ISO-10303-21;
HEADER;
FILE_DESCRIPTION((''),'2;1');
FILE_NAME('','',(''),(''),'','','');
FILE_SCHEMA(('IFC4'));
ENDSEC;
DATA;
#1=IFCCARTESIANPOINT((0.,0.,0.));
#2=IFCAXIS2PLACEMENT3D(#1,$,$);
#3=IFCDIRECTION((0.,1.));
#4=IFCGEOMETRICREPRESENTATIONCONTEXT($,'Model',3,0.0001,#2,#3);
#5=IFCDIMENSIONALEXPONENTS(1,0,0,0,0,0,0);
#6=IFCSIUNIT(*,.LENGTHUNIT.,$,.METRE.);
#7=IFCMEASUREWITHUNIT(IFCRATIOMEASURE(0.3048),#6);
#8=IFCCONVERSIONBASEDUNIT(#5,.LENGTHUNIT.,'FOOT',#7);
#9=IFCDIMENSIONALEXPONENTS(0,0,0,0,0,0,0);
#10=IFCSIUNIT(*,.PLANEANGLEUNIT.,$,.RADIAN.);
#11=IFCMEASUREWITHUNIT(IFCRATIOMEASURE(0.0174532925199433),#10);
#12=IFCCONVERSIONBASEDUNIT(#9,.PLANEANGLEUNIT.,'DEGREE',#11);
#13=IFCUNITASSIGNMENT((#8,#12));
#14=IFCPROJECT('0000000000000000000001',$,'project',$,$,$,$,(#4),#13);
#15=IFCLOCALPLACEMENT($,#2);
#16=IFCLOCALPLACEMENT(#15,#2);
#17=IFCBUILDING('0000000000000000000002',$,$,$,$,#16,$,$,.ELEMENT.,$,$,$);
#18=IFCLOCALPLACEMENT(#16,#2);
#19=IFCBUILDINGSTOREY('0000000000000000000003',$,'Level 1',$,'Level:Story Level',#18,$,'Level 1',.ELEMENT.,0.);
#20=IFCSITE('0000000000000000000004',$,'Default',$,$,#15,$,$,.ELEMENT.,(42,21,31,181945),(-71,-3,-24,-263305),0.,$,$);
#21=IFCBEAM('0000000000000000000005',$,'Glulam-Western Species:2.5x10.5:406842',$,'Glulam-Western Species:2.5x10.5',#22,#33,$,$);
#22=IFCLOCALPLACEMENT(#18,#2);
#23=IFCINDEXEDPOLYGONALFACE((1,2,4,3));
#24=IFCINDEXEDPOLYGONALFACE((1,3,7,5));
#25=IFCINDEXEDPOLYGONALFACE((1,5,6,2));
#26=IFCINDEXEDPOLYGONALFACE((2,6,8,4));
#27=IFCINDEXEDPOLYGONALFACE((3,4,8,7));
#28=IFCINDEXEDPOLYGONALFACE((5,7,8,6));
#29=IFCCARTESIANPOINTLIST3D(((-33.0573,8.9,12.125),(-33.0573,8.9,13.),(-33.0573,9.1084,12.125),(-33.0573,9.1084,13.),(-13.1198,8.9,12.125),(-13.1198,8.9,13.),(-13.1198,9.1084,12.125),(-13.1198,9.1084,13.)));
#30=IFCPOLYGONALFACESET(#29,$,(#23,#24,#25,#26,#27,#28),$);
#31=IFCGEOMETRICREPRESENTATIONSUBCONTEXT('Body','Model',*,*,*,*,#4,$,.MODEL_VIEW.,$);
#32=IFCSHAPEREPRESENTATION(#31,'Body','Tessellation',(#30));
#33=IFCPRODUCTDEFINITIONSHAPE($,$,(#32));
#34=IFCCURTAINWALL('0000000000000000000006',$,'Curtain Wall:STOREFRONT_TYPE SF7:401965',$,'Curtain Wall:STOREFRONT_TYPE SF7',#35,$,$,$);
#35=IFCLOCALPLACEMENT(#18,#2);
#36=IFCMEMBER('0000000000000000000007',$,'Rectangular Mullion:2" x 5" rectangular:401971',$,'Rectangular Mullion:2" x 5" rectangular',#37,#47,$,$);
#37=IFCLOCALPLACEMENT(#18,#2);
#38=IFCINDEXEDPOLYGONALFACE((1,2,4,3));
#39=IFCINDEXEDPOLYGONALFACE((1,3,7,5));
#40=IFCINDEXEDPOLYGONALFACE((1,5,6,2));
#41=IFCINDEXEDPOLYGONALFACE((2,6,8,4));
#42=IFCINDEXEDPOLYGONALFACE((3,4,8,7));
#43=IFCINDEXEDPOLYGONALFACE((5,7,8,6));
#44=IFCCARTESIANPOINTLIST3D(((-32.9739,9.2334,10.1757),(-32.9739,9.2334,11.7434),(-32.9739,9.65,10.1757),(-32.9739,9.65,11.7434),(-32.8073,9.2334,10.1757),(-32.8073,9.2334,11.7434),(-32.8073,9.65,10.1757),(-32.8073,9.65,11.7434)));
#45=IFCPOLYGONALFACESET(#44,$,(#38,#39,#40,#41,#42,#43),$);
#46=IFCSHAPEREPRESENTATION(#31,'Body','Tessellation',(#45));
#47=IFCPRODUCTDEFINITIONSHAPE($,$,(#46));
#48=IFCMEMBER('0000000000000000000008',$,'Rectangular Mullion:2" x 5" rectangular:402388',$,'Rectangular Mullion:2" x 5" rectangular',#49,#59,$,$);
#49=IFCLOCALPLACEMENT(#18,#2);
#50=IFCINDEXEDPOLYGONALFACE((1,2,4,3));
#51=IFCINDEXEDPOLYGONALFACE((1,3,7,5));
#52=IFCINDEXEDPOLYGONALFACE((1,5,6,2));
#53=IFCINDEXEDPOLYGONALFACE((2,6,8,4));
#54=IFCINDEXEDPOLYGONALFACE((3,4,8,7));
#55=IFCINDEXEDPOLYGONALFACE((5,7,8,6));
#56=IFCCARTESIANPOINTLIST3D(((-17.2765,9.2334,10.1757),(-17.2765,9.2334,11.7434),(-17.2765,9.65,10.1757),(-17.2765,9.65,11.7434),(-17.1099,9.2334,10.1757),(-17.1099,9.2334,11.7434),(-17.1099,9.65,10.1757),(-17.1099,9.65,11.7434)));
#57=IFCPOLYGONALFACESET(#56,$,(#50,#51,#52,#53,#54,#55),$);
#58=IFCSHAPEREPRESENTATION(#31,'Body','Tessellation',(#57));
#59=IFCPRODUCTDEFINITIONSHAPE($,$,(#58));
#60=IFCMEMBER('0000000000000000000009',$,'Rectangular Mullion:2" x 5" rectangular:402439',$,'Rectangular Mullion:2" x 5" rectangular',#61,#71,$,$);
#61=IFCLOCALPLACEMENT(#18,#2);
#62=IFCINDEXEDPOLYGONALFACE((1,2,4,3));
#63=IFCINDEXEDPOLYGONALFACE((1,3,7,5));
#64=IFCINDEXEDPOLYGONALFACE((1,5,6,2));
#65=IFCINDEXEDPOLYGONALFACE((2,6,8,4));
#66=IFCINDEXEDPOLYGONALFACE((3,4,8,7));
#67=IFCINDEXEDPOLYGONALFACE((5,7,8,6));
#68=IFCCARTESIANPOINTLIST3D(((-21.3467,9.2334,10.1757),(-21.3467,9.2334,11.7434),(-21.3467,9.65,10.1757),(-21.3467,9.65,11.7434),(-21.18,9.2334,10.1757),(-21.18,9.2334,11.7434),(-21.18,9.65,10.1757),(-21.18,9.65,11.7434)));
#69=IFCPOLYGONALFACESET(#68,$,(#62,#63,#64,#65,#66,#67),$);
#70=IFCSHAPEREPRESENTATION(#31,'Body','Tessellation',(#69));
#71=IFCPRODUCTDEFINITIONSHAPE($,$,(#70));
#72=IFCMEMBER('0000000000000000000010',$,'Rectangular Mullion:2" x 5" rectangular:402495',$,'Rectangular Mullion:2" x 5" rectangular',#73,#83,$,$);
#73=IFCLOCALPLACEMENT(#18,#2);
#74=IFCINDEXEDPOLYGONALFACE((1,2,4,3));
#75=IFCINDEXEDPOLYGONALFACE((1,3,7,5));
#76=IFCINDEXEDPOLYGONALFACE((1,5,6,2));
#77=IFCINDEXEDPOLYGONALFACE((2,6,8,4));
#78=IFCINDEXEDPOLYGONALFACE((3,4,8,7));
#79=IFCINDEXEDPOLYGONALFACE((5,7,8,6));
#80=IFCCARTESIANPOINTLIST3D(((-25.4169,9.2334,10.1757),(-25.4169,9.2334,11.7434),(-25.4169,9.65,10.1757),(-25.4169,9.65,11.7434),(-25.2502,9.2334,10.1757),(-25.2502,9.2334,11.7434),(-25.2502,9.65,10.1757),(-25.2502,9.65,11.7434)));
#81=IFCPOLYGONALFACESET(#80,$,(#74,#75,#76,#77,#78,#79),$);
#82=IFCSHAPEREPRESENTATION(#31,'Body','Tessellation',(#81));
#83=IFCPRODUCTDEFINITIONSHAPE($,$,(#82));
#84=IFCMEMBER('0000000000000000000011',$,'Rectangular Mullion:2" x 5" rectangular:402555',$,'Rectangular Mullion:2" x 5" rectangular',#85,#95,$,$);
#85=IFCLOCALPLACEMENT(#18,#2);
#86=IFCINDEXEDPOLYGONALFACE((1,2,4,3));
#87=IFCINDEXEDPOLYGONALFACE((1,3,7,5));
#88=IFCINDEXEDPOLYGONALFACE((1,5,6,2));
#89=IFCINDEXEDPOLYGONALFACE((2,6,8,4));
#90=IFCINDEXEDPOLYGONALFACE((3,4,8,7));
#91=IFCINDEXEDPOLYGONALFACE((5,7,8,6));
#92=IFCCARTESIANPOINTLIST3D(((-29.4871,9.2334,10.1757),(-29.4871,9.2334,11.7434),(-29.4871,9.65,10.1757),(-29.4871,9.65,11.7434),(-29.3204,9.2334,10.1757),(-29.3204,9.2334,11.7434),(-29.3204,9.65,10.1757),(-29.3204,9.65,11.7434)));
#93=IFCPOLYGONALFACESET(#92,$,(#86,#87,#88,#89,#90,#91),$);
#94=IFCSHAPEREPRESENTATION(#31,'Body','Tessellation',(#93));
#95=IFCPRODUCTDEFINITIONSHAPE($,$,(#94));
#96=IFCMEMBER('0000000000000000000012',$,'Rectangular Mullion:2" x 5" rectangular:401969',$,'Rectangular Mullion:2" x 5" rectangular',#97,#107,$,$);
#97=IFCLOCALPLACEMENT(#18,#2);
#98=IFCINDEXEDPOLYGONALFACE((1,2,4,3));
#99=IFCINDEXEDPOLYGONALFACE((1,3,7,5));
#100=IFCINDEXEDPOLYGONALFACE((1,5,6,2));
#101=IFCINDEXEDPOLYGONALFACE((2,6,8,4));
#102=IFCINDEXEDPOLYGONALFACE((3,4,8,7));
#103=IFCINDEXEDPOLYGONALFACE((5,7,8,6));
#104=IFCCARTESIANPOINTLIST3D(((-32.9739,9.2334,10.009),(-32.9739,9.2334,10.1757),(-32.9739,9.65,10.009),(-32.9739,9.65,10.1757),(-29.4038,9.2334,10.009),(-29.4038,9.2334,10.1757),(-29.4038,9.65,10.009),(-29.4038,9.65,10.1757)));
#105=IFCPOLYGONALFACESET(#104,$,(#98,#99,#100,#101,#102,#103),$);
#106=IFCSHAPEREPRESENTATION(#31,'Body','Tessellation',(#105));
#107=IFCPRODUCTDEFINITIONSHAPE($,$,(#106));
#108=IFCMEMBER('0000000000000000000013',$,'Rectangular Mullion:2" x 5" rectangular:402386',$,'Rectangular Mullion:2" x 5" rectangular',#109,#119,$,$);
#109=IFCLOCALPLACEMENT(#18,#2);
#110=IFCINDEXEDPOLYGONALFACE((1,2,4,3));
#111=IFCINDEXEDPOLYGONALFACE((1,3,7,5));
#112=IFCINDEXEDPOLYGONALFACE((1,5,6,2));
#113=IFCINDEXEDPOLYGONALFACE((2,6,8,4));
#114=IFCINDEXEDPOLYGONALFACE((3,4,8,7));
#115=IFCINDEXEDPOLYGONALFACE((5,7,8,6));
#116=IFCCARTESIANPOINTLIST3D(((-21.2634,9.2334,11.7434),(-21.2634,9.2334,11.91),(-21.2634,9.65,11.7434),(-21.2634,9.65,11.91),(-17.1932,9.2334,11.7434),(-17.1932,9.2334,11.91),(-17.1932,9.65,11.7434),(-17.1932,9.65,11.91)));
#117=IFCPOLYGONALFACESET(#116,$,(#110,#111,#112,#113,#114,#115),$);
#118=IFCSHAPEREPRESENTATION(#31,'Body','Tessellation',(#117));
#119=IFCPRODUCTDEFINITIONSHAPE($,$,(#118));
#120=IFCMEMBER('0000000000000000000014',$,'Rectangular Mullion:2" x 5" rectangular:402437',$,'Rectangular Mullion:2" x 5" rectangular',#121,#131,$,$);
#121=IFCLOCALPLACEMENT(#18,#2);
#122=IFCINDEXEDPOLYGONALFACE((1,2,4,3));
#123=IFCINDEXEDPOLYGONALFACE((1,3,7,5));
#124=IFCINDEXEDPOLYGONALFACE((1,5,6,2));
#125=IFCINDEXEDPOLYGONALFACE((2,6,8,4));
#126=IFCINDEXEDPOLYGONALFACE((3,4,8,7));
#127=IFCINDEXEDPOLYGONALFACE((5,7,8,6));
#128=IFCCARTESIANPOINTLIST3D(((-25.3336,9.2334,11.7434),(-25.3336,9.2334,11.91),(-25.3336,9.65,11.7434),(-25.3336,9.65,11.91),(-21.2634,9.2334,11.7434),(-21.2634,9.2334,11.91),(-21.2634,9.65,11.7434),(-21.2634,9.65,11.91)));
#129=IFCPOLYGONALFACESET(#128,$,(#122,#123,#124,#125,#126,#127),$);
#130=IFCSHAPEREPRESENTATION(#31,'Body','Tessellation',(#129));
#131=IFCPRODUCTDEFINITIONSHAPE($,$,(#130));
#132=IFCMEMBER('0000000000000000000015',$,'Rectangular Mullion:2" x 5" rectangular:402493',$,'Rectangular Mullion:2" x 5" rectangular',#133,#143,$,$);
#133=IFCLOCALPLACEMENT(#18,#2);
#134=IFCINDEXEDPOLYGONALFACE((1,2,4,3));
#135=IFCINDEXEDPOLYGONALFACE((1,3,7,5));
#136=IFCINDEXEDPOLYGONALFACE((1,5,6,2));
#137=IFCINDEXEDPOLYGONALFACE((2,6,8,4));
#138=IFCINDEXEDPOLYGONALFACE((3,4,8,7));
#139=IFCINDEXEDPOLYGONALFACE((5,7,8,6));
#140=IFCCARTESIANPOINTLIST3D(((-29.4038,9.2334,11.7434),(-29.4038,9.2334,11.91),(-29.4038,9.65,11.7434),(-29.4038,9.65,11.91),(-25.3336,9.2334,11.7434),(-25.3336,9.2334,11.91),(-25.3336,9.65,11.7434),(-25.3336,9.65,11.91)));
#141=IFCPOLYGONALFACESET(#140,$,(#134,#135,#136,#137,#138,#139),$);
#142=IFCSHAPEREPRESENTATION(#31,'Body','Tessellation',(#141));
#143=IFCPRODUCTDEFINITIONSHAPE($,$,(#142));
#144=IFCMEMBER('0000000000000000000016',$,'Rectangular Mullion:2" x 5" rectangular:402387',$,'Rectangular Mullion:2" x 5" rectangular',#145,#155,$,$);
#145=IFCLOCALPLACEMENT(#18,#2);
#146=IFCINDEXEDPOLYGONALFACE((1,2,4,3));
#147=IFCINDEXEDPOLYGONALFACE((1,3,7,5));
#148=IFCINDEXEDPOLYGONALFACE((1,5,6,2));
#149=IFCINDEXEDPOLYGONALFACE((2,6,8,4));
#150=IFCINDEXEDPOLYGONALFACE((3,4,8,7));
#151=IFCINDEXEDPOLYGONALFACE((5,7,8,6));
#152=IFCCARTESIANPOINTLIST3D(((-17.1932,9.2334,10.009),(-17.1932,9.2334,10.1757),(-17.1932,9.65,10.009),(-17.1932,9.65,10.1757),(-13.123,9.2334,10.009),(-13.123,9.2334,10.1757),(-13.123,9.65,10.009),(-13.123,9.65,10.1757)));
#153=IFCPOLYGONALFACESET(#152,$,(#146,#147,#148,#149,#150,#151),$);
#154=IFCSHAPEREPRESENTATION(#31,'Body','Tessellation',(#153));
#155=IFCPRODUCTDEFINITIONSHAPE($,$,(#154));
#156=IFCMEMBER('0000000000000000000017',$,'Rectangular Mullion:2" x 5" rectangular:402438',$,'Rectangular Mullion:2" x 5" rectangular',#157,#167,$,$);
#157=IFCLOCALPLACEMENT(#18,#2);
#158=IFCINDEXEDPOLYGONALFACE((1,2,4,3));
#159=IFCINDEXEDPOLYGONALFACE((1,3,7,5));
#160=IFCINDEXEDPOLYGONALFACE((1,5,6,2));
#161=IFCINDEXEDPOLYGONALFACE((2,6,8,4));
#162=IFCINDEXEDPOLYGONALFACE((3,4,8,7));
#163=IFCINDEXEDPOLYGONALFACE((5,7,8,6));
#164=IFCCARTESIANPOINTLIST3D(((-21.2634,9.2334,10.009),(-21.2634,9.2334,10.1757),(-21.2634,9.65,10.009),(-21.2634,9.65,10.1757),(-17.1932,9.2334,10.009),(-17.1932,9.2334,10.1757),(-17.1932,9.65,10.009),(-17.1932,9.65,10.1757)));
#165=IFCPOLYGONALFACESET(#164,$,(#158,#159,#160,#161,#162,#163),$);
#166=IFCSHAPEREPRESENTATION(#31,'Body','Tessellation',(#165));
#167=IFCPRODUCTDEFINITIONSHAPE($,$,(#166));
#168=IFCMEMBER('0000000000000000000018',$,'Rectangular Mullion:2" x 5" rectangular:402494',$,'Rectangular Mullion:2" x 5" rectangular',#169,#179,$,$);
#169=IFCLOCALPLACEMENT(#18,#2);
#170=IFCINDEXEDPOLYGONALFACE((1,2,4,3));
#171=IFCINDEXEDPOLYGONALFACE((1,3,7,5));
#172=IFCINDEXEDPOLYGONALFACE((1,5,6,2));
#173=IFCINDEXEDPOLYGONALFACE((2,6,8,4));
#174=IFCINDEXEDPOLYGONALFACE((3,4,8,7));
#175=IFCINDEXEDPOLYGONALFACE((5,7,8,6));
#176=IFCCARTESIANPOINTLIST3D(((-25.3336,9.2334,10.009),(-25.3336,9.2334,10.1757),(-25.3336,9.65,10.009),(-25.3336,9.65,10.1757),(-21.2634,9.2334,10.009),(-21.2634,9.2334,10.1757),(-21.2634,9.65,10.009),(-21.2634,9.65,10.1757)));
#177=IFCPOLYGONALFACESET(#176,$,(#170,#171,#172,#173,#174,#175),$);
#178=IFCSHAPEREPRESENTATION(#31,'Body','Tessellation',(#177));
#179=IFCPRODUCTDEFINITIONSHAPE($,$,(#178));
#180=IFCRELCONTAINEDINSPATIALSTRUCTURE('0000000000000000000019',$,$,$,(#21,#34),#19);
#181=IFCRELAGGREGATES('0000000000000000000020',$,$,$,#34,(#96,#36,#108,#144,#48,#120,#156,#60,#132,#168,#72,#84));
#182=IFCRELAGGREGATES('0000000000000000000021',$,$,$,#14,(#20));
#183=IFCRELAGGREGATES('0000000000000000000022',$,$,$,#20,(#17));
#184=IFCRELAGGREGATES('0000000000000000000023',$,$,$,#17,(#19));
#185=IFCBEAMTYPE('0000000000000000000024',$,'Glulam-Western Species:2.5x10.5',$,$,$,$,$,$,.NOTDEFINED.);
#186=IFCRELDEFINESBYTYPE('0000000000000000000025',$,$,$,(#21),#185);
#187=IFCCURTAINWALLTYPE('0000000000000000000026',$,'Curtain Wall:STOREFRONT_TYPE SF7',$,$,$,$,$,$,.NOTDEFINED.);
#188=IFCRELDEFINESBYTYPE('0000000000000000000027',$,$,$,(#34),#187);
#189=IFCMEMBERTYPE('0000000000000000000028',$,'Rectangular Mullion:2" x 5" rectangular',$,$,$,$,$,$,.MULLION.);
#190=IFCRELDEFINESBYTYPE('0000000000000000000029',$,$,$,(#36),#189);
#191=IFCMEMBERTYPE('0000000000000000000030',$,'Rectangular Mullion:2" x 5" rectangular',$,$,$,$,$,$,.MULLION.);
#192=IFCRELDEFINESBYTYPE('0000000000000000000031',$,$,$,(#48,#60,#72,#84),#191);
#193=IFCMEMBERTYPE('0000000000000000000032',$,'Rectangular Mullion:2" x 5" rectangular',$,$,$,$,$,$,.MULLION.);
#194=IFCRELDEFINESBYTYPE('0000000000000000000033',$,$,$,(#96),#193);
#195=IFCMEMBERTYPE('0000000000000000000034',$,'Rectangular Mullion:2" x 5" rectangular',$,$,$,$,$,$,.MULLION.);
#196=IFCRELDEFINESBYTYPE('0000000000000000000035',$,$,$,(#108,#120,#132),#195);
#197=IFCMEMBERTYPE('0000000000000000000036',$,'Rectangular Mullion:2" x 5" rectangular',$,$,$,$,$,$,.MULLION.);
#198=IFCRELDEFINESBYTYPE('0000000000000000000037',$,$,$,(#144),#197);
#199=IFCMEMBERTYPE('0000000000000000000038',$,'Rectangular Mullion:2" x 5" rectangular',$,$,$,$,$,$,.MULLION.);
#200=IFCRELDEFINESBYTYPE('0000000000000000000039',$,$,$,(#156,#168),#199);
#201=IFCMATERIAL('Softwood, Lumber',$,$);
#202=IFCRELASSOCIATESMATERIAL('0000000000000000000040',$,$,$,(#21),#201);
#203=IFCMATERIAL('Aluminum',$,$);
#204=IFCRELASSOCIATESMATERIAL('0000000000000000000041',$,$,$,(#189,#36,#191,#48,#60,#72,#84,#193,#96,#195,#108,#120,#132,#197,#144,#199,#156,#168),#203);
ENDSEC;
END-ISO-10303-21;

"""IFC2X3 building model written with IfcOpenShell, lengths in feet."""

from ifc_helpers import new_model, entity, si_unit, converted_unit, direction, frame, frame_2d, origin, origin_2d_with_axis, place, context, subcontext, project, spatial, rectangle, extrude, source, transform, mapped, material, type_object, type_shapes, element, aggregate, save


model = new_model("IFC2X3")

# Units and contexts
model_context = context("Model", 3, precision=0.0001, world=origin(), true_north=direction((0.0, 1.0)))
body_context = subcontext(model_context, "Body", "Model", "MODEL_VIEW")
ifc_project = project(units=[converted_unit("LENGTHUNIT", "FOOT", entity("IfcRatioMeasure", 0.3048), si_unit("LENGTHUNIT", "METRE"), dimensions=[1, 0, 0, 0, 0, 0, 0]), converted_unit("PLANEANGLEUNIT", "DEGREE", entity("IfcRatioMeasure", 0.0174532925199433), si_unit("PLANEANGLEUNIT", "RADIAN"), dimensions=[0, 0, 0, 0, 0, 0, 0])], contexts=[model_context])

# Site, building, storey
site_placement = place(None, origin())
site = spatial("IfcSite", under=ifc_project, at=site_placement, Name="Default", CompositionType="ELEMENT", RefLatitude=(42, 21, 31, 181945), RefLongitude=(-71, -3, -24, -263305), RefElevation=0.0)
building_placement = place(site_placement, origin())
building = spatial("IfcBuilding", under=site, at=building_placement, CompositionType="ELEMENT")
storey_placement = place(building_placement, origin())
storey = spatial("IfcBuildingStorey", under=building, at=storey_placement, Name="Level 1", ObjectType="Level:Story Level", LongName="Level 1", CompositionType="ELEMENT", Elevation=0.0)

# Beam
ifc_material_1 = material(Name="Softwood, Lumber")
beam_type = type_object("IfcBeamType", Name="Glulam-Western Species:2.5x10.5", PredefinedType="NOTDEFINED")
beam_placement = place(storey_placement, frame((-40.0989, 9.0042, 13.0)))
element("IfcBeam", 1, at=beam_placement, inside=storey, type_object=beam_type, material=ifc_material_1, Name="Glulam-Western Species:2.5x10.5:406842", ObjectType="Glulam-Western Species:2.5x10.5", context=body_context, shape_type="SweptSolid", body=[
    extrude(rectangle(XDim=0.875, YDim=0.2083, at=frame_2d((0.0, 0.0), x_axis=(1.0, 0.0))), frame((7.0417, 0.0, -0.4375), z_axis=(1.0, 0.0, 0.0), x_axis=(0.0, 0.0, -1.0)), (0.0, 0.0, 1.0), 19.9375),
])

# Curtain wall, members
curtain_wall_type = type_object("IfcCurtainWallType", Name="Curtain Wall:STOREFRONT_TYPE SF7", PredefinedType="NOTDEFINED")
curtain_wall_placement = place(storey_placement, origin())
curtain_wall = element("IfcCurtainWall", 2, at=curtain_wall_placement, inside=storey, type_object=curtain_wall_type, Name="Curtain Wall:STOREFRONT_TYPE SF7:401965", ObjectType="Curtain Wall:STOREFRONT_TYPE SF7")
ifc_material_2 = material(Name="Aluminum")
member_type_1 = type_object("IfcMemberType", Name="Rectangular Mullion:2\" x 5\" rectangular", PredefinedType="MULLION", material=ifc_material_2)
shared_shape_1 = source(origin(), body_context, "Body", "SweptSolid", [
    extrude(rectangle(XDim=0.4167, YDim=0.1667, at=origin_2d_with_axis()), frame((-0.0833, 0.0, -1.5677), z_axis=(0.0, 0.0, 1.0), x_axis=(0.0, -1.0, 0.0)), (0.0, 0.0, 1.0), 1.5677),
])
type_shapes(member_type_1, [shared_shape_1])
member_1_placement = place(curtain_wall_placement, frame((-32.9739, 9.4417, 11.7434), z_axis=(0.0, 0.0, 1.0), x_axis=(-1.0, 0.0, 0.0)))
member_1 = element("IfcMember", 3, at=member_1_placement, type_object=member_type_1, material=ifc_material_2, Name="Rectangular Mullion:2\" x 5\" rectangular:401971", ObjectType="Rectangular Mullion:2\" x 5\" rectangular", context=body_context, shape_type="MappedRepresentation", body=[
    mapped(shared_shape_1, transform((0.0, 0.0, 0.0), scale=1.0)),
])
member_type_2 = type_object("IfcMemberType", Name="Rectangular Mullion:2\" x 5\" rectangular", PredefinedType="MULLION", material=ifc_material_2)
shared_shape_2 = source(origin(), body_context, "Body", "SweptSolid", [
    extrude(rectangle(XDim=0.4167, YDim=0.1667, at=origin_2d_with_axis()), frame((0.0, 0.0, -1.5677), z_axis=(0.0, 0.0, 1.0), x_axis=(0.0, -1.0, 0.0)), (0.0, 0.0, 1.0), 1.5677),
])
type_shapes(member_type_2, [shared_shape_2])
member_2_placement = place(curtain_wall_placement, frame((-17.1932, 9.4417, 10.1757), z_axis=(0.0, 0.0, -1.0), x_axis=(1.0, 0.0, 0.0)))
member_2 = element("IfcMember", 4, at=member_2_placement, type_object=member_type_2, material=ifc_material_2, Name="Rectangular Mullion:2\" x 5\" rectangular:402388", ObjectType="Rectangular Mullion:2\" x 5\" rectangular", context=body_context, shape_type="MappedRepresentation", body=[
    mapped(shared_shape_2, transform((0.0, 0.0, 0.0), scale=1.0)),
])
member_3_placement = place(curtain_wall_placement, frame((-21.2634, 9.4417, 10.1757), z_axis=(0.0, 0.0, -1.0), x_axis=(1.0, 0.0, 0.0)))
member_3 = element("IfcMember", 5, at=member_3_placement, type_object=member_type_2, material=ifc_material_2, Name="Rectangular Mullion:2\" x 5\" rectangular:402439", ObjectType="Rectangular Mullion:2\" x 5\" rectangular", context=body_context, shape_type="MappedRepresentation", body=[
    mapped(shared_shape_2, transform((0.0, 0.0, 0.0), scale=1.0)),
])
member_4_placement = place(curtain_wall_placement, frame((-25.3336, 9.4417, 10.1757), z_axis=(0.0, 0.0, -1.0), x_axis=(1.0, 0.0, 0.0)))
member_4 = element("IfcMember", 6, at=member_4_placement, type_object=member_type_2, material=ifc_material_2, Name="Rectangular Mullion:2\" x 5\" rectangular:402495", ObjectType="Rectangular Mullion:2\" x 5\" rectangular", context=body_context, shape_type="MappedRepresentation", body=[
    mapped(shared_shape_2, transform((0.0, 0.0, 0.0), scale=1.0)),
])
member_5_placement = place(curtain_wall_placement, frame((-29.4038, 9.4417, 10.1757), z_axis=(0.0, 0.0, -1.0), x_axis=(1.0, 0.0, 0.0)))
member_5 = element("IfcMember", 7, at=member_5_placement, type_object=member_type_2, material=ifc_material_2, Name="Rectangular Mullion:2\" x 5\" rectangular:402555", ObjectType="Rectangular Mullion:2\" x 5\" rectangular", context=body_context, shape_type="MappedRepresentation", body=[
    mapped(shared_shape_2, transform((0.0, 0.0, 0.0), scale=1.0)),
])
member_type_3 = type_object("IfcMemberType", Name="Rectangular Mullion:2\" x 5\" rectangular", PredefinedType="MULLION", material=ifc_material_2)
shared_shape_3 = source(origin(), body_context, "Body", "SweptSolid", [
    extrude(rectangle(XDim=0.4167, YDim=0.1667, at=origin_2d_with_axis()), frame((-0.0833, 0.0, -3.5702), z_axis=(0.0, 0.0, 1.0), x_axis=(0.0, -1.0, 0.0)), (0.0, 0.0, 1.0), 3.5702),
])
type_shapes(member_type_3, [shared_shape_3])
member_6_placement = place(curtain_wall_placement, frame((-32.9739, 9.4417, 10.009), z_axis=(-1.0, 0.0, 0.0), x_axis=(0.0, 0.0, -1.0)))
member_6 = element("IfcMember", 8, at=member_6_placement, type_object=member_type_3, material=ifc_material_2, Name="Rectangular Mullion:2\" x 5\" rectangular:401969", ObjectType="Rectangular Mullion:2\" x 5\" rectangular", context=body_context, shape_type="MappedRepresentation", body=[
    mapped(shared_shape_3, transform((0.0, 0.0, 0.0), scale=1.0)),
])
member_type_4 = type_object("IfcMemberType", Name="Rectangular Mullion:2\" x 5\" rectangular", PredefinedType="MULLION", material=ifc_material_2)
shared_shape_4 = source(origin(), body_context, "Body", "SweptSolid", [
    extrude(rectangle(XDim=0.4167, YDim=0.1667, at=origin_2d_with_axis()), frame((-0.0833, 0.0, -4.0702), z_axis=(0.0, 0.0, 1.0), x_axis=(0.0, -1.0, 0.0)), (0.0, 0.0, 1.0), 4.0702),
])
type_shapes(member_type_4, [shared_shape_4])
member_7_placement = place(curtain_wall_placement, frame((-17.1932, 9.4417, 11.91), z_axis=(1.0, 0.0, 0.0), x_axis=(0.0, 0.0, 1.0)))
member_7 = element("IfcMember", 9, at=member_7_placement, type_object=member_type_4, material=ifc_material_2, Name="Rectangular Mullion:2\" x 5\" rectangular:402386", ObjectType="Rectangular Mullion:2\" x 5\" rectangular", context=body_context, shape_type="MappedRepresentation", body=[
    mapped(shared_shape_4, transform((0.0, 0.0, 0.0), scale=1.0)),
])
member_8_placement = place(curtain_wall_placement, frame((-21.2634, 9.4417, 11.91), z_axis=(1.0, 0.0, 0.0), x_axis=(0.0, 0.0, 1.0)))
member_8 = element("IfcMember", 10, at=member_8_placement, type_object=member_type_4, material=ifc_material_2, Name="Rectangular Mullion:2\" x 5\" rectangular:402437", ObjectType="Rectangular Mullion:2\" x 5\" rectangular", context=body_context, shape_type="MappedRepresentation", body=[
    mapped(shared_shape_4, transform((0.0, 0.0, 0.0), scale=1.0)),
])
member_9_placement = place(curtain_wall_placement, frame((-25.3336, 9.4417, 11.91), z_axis=(1.0, 0.0, 0.0), x_axis=(0.0, 0.0, 1.0)))
member_9 = element("IfcMember", 11, at=member_9_placement, type_object=member_type_4, material=ifc_material_2, Name="Rectangular Mullion:2\" x 5\" rectangular:402493", ObjectType="Rectangular Mullion:2\" x 5\" rectangular", context=body_context, shape_type="MappedRepresentation", body=[
    mapped(shared_shape_4, transform((0.0, 0.0, 0.0), scale=1.0)),
])
member_type_5 = type_object("IfcMemberType", Name="Rectangular Mullion:2\" x 5\" rectangular", PredefinedType="MULLION", material=ifc_material_2)
shared_shape_5 = source(origin(), body_context, "Body", "SweptSolid", [
    extrude(rectangle(XDim=0.4167, YDim=0.1667, at=origin_2d_with_axis()), frame((-0.0833, 0.0, -4.0702), z_axis=(0.0, 0.0, 1.0), x_axis=(0.0, -1.0, 0.0)), (0.0, 0.0, 1.0), 4.0702),
])
type_shapes(member_type_5, [shared_shape_5])
member_10_placement = place(curtain_wall_placement, frame((-17.1932, 9.4417, 10.009), z_axis=(-1.0, 0.0, 0.0), x_axis=(0.0, 0.0, -1.0)))
member_10 = element("IfcMember", 12, at=member_10_placement, type_object=member_type_5, material=ifc_material_2, Name="Rectangular Mullion:2\" x 5\" rectangular:402387", ObjectType="Rectangular Mullion:2\" x 5\" rectangular", context=body_context, shape_type="MappedRepresentation", body=[
    mapped(shared_shape_5, transform((0.0, 0.0, 0.0), scale=1.0)),
])
member_type_6 = type_object("IfcMemberType", Name="Rectangular Mullion:2\" x 5\" rectangular", PredefinedType="MULLION", material=ifc_material_2)
shared_shape_6 = source(origin(), body_context, "Body", "SweptSolid", [
    extrude(rectangle(XDim=0.4167, YDim=0.1667, at=origin_2d_with_axis()), frame((-0.0833, 0.0, -4.0702), z_axis=(0.0, 0.0, 1.0), x_axis=(0.0, -1.0, 0.0)), (0.0, 0.0, 1.0), 4.0702),
])
type_shapes(member_type_6, [shared_shape_6])
member_11_placement = place(curtain_wall_placement, frame((-21.2634, 9.4417, 10.009), z_axis=(-1.0, 0.0, 0.0), x_axis=(0.0, 0.0, -1.0)))
member_11 = element("IfcMember", 13, at=member_11_placement, type_object=member_type_6, material=ifc_material_2, Name="Rectangular Mullion:2\" x 5\" rectangular:402438", ObjectType="Rectangular Mullion:2\" x 5\" rectangular", context=body_context, shape_type="MappedRepresentation", body=[
    mapped(shared_shape_6, transform((0.0, 0.0, 0.0), scale=1.0)),
])
member_12_placement = place(curtain_wall_placement, frame((-25.3336, 9.4417, 10.009), z_axis=(-1.0, 0.0, 0.0), x_axis=(0.0, 0.0, -1.0)))
member_12 = element("IfcMember", 14, at=member_12_placement, type_object=member_type_6, material=ifc_material_2, Name="Rectangular Mullion:2\" x 5\" rectangular:402494", ObjectType="Rectangular Mullion:2\" x 5\" rectangular", context=body_context, shape_type="MappedRepresentation", body=[
    mapped(shared_shape_6, transform((0.0, 0.0, 0.0), scale=1.0)),
])
aggregate(curtain_wall, [member_6, member_1, member_7, member_10, member_2, member_8, member_11, member_3, member_9, member_12, member_4, member_5])

save(model, "model.ifc")
